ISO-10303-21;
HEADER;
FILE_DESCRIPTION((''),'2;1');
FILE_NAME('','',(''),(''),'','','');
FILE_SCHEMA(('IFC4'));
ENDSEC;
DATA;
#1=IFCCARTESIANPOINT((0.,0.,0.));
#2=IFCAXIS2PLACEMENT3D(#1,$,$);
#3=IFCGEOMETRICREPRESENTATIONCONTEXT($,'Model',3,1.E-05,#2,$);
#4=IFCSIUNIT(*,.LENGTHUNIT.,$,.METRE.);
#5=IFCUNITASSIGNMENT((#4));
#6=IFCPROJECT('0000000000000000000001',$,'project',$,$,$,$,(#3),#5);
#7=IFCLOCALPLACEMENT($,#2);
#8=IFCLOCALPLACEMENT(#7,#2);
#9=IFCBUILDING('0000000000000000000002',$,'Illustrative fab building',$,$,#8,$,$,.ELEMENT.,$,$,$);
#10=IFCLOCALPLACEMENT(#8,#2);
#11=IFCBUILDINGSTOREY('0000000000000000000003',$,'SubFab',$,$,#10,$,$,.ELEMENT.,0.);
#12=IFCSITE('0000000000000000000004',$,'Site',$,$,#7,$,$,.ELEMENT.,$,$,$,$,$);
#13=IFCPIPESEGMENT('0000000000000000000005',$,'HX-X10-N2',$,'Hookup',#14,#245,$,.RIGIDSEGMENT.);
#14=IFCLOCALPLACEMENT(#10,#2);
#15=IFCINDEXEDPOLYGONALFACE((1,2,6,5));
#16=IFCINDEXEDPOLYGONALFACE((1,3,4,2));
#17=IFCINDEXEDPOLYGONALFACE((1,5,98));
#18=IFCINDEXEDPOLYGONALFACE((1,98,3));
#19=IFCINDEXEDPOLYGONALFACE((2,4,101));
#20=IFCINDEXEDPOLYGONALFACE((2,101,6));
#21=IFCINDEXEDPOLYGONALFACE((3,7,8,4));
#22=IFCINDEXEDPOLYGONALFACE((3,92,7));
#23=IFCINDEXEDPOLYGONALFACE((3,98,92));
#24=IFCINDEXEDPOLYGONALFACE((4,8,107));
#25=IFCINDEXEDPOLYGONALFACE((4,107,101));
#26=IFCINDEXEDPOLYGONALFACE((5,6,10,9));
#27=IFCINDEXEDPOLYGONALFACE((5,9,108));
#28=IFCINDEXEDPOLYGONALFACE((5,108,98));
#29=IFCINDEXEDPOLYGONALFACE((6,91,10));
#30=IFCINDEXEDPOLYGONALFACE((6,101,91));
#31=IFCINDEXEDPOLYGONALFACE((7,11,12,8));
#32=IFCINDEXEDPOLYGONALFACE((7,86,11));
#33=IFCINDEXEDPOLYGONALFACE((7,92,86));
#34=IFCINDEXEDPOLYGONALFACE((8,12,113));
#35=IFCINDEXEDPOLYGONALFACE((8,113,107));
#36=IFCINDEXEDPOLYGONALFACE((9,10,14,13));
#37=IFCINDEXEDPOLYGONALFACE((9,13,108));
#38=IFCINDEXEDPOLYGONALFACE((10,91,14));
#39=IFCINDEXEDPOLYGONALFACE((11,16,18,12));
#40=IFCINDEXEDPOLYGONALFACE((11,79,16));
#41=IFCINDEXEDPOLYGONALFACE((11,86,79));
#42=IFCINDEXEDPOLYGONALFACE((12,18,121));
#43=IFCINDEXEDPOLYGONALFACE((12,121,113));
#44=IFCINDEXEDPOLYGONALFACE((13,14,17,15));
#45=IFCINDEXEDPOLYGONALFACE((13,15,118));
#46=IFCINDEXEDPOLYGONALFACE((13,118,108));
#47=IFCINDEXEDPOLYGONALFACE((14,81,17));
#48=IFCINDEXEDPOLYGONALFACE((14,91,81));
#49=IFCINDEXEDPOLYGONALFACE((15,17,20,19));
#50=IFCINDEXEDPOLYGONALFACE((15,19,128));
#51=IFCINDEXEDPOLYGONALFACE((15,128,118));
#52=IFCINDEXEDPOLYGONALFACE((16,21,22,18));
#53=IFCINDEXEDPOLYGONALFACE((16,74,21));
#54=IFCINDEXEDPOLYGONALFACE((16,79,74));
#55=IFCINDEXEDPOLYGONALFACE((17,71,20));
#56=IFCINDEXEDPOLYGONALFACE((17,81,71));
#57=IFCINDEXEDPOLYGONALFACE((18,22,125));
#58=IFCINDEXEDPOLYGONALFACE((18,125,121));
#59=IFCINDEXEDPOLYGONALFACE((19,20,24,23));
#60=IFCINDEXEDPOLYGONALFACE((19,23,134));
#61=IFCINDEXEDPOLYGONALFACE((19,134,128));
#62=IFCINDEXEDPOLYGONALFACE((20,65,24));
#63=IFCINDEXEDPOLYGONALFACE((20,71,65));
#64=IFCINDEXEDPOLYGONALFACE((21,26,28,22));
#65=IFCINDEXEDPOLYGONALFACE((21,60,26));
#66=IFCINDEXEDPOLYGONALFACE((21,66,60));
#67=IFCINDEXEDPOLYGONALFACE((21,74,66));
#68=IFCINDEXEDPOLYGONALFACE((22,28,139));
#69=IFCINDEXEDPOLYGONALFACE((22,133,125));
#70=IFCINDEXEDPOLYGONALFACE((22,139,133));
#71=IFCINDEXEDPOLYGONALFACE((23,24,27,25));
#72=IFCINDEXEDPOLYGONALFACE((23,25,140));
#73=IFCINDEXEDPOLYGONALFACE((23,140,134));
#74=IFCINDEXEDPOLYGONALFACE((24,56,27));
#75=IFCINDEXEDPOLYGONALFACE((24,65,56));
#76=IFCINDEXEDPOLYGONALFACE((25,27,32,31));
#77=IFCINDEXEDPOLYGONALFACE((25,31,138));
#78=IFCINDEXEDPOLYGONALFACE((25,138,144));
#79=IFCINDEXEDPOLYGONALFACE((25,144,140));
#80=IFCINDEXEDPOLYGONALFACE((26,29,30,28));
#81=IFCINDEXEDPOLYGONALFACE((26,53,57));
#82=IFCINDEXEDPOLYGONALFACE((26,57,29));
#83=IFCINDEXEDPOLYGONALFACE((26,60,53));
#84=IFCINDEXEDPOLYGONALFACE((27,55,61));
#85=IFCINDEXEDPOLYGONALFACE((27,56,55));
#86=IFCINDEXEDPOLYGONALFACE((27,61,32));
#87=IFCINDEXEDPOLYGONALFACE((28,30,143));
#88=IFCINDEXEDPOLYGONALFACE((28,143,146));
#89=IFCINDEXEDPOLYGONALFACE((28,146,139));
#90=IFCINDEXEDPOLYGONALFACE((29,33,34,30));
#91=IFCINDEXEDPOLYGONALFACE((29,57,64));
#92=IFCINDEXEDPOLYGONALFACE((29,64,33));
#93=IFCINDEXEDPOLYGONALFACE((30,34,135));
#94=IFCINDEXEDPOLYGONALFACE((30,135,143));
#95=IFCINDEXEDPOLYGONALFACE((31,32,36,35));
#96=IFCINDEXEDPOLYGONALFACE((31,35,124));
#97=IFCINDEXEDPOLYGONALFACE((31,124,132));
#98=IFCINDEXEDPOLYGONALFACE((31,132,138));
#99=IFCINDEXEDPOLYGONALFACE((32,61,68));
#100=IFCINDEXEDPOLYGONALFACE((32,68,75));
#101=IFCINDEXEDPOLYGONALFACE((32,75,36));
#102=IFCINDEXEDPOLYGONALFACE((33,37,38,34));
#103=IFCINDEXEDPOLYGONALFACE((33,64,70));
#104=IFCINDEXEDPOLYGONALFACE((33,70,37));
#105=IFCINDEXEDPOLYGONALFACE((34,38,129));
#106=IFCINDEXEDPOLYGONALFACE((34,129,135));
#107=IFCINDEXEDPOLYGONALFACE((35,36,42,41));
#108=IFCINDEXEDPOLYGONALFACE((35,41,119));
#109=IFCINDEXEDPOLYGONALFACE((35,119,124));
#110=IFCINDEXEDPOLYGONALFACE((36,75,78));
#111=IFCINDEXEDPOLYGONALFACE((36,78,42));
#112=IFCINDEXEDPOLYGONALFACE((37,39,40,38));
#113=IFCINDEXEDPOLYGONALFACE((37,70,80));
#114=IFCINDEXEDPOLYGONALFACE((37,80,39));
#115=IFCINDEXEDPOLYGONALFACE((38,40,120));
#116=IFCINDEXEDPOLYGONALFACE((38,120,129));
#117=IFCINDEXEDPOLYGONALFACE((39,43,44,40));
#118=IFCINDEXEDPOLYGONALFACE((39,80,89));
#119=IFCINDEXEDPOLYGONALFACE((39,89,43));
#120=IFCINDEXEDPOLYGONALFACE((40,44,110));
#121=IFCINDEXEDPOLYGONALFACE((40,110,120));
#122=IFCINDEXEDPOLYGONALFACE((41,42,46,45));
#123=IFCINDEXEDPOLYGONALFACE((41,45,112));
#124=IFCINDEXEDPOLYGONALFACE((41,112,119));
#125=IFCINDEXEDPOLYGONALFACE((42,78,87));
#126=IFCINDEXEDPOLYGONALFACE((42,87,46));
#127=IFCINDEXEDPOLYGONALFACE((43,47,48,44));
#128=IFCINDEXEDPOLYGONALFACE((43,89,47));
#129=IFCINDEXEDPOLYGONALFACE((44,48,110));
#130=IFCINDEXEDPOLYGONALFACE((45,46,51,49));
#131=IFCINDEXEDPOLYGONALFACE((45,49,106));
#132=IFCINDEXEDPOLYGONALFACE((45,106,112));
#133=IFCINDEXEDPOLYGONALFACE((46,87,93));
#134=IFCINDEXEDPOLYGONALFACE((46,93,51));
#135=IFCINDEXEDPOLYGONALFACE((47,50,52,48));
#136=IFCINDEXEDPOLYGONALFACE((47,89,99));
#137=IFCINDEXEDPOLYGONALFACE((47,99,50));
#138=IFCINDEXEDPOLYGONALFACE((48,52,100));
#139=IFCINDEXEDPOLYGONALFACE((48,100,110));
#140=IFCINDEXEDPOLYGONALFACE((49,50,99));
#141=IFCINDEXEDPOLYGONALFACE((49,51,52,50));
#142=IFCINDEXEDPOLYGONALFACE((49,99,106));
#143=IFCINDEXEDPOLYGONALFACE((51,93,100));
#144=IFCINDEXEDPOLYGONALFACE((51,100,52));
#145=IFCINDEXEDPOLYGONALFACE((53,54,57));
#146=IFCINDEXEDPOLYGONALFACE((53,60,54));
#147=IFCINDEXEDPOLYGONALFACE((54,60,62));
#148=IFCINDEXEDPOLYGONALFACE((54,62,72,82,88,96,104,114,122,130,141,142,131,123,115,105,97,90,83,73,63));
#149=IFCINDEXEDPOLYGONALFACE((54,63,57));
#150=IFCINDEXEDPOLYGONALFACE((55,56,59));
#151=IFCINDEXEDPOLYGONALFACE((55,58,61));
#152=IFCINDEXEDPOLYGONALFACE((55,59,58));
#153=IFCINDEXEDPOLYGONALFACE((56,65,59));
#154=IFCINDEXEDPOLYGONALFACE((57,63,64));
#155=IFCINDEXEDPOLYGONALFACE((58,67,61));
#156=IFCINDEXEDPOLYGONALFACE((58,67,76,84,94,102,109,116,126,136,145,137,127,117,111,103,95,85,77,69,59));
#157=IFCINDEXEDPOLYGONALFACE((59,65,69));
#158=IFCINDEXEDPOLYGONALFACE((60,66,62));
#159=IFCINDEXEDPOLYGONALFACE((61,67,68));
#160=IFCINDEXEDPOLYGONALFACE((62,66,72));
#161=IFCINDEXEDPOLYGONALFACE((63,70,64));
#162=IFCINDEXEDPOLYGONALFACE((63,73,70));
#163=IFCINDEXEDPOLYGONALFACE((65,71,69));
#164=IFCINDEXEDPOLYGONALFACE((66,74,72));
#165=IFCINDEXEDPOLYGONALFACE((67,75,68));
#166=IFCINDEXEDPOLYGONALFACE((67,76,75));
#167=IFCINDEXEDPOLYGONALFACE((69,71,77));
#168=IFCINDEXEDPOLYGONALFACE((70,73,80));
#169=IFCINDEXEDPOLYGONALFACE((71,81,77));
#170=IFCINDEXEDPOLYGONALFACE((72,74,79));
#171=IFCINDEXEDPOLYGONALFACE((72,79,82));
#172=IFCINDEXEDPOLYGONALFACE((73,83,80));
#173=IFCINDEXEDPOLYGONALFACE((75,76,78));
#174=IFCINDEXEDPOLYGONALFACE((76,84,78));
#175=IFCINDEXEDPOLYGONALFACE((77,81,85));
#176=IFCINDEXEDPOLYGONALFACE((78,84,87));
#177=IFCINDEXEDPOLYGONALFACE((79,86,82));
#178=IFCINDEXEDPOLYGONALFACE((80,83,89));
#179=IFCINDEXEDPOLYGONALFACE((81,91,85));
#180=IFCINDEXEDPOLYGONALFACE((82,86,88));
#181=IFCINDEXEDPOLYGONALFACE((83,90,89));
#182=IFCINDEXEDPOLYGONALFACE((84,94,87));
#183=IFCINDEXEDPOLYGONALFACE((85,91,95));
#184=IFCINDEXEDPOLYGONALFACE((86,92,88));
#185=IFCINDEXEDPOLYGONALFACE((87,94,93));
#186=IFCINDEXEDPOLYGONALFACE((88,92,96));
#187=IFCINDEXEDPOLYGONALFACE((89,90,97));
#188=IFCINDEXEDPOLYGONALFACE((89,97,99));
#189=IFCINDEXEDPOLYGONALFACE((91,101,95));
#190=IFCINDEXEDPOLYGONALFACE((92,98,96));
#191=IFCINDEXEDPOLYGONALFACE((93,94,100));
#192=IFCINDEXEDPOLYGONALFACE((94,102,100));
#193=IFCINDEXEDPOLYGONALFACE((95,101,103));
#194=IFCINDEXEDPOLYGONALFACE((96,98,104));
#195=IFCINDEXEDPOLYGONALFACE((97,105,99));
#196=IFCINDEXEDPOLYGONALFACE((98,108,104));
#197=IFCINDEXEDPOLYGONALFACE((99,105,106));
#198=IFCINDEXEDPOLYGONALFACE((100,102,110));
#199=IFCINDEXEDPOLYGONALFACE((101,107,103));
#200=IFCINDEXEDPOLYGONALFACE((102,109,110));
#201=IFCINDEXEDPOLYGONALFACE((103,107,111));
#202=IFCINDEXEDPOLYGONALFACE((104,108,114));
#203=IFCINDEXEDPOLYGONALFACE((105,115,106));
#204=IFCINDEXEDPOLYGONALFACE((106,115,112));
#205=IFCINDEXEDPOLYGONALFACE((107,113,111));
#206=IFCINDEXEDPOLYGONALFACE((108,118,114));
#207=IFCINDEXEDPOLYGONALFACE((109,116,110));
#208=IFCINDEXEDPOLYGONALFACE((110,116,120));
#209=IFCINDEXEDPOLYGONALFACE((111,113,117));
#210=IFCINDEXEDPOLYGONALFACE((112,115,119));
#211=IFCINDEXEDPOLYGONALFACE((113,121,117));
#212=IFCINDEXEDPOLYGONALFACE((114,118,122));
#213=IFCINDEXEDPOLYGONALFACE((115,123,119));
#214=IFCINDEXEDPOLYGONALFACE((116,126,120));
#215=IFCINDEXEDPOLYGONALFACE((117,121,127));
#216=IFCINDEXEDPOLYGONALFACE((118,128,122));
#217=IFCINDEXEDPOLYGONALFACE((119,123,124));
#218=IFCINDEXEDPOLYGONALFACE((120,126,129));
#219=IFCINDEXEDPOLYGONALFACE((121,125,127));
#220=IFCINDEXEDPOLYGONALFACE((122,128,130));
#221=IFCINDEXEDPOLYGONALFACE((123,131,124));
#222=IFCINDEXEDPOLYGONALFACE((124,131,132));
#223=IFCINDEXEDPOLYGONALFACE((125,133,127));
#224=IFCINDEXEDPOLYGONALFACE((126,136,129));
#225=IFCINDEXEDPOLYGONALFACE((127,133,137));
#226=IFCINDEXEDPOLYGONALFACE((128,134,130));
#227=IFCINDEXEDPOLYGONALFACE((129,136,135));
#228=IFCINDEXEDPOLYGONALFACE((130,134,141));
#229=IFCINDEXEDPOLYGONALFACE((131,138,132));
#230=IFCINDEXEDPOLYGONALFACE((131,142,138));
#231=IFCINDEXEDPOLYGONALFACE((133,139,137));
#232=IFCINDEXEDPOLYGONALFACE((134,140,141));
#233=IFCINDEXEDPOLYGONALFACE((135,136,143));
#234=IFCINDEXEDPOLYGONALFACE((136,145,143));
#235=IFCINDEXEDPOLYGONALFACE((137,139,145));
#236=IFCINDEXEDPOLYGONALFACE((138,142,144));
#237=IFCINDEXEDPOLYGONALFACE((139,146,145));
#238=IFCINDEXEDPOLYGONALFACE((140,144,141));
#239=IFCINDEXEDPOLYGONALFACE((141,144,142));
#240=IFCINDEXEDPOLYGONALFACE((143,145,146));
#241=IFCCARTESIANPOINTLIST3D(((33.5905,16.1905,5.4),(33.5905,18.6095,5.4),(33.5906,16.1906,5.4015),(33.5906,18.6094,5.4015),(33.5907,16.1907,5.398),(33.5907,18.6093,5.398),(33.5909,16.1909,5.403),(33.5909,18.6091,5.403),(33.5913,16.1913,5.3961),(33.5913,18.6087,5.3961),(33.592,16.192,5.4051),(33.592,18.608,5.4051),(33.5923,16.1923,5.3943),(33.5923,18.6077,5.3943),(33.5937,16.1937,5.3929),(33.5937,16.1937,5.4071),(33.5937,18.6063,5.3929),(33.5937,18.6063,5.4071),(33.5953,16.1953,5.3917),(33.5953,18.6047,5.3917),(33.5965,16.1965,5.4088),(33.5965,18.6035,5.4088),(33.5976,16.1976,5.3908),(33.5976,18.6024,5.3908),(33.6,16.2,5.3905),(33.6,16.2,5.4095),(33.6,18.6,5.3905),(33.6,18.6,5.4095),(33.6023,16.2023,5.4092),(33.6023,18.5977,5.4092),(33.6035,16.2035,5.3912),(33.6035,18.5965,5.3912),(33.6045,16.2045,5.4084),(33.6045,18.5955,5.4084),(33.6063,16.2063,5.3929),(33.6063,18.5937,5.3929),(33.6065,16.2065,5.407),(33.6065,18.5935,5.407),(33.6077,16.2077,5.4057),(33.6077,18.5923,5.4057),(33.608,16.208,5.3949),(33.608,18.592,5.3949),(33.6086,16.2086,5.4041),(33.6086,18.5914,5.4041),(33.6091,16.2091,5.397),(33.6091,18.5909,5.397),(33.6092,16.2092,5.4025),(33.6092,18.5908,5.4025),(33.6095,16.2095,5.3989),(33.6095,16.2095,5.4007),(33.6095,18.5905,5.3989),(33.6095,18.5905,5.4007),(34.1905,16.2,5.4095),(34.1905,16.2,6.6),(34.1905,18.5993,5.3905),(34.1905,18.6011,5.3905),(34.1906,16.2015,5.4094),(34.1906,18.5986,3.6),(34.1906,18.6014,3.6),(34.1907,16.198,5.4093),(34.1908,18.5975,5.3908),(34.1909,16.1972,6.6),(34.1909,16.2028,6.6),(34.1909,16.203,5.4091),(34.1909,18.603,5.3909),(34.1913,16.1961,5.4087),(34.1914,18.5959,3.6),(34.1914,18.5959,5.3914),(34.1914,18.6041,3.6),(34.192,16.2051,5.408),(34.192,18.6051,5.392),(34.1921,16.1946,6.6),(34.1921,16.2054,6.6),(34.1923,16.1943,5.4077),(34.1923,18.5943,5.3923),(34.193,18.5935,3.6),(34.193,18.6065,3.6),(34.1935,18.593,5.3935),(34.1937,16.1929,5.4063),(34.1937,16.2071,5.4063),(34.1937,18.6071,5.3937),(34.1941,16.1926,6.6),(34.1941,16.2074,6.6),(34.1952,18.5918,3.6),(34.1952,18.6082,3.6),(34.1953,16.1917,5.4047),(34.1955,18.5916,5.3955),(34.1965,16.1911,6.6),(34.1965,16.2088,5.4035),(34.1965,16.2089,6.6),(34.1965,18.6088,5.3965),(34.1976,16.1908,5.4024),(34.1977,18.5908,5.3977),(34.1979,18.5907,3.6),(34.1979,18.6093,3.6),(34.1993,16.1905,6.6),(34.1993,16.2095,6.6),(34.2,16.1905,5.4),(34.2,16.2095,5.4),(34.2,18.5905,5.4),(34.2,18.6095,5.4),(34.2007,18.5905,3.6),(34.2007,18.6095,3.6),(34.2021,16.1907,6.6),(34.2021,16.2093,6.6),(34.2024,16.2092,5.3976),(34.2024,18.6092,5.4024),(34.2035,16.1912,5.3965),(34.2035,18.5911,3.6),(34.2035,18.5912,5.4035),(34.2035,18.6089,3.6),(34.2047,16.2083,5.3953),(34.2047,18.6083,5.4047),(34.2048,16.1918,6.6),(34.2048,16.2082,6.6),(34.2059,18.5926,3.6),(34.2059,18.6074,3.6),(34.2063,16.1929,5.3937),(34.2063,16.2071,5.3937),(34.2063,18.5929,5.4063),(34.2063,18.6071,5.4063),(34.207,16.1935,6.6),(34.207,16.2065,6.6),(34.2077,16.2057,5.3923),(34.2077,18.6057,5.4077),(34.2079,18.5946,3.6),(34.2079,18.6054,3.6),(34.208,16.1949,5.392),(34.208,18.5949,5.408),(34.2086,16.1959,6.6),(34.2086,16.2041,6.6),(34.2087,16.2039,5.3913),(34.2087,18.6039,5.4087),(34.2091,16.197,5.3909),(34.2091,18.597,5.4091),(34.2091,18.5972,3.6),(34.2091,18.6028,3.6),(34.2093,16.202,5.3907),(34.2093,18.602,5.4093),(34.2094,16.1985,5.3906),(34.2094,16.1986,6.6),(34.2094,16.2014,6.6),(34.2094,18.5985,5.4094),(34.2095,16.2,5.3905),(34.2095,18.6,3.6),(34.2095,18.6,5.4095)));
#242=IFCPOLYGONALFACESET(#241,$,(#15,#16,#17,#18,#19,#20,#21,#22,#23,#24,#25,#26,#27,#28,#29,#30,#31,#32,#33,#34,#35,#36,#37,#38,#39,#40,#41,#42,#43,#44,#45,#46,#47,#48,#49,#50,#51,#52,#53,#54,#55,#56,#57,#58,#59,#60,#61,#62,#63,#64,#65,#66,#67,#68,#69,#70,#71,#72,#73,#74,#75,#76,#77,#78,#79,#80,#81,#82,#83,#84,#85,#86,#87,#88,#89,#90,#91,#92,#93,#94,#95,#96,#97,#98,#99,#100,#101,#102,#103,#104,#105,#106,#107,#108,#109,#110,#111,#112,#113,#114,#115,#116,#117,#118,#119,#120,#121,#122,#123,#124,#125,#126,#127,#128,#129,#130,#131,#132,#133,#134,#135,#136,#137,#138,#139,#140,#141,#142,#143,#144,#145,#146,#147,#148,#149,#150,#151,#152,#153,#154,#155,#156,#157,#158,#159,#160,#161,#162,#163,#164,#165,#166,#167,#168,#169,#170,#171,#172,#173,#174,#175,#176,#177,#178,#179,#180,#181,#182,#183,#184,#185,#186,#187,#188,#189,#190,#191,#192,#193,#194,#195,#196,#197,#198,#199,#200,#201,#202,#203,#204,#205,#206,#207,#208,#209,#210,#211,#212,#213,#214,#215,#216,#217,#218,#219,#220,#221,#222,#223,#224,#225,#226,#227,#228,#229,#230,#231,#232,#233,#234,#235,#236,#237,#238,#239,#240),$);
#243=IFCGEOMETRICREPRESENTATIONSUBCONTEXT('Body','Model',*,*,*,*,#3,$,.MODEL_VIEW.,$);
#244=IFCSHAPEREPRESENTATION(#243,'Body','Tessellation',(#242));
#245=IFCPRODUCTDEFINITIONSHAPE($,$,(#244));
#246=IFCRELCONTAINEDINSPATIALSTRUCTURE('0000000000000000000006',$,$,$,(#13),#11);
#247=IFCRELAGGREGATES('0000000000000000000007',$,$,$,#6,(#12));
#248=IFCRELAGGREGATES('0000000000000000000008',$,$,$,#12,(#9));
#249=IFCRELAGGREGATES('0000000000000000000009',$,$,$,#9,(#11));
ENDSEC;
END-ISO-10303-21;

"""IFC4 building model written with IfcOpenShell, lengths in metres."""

from ifc_helpers import new_model, entity, si_unit, origin, place, context, subcontext, project, spatial, element, save


model = new_model("IFC4")

# Units and contexts
model_context = context("Model", 3, precision=1e-05, world=origin())
body_context = subcontext(model_context, "Body", "Model", "MODEL_VIEW")
ifc_project = project(units=[si_unit("LENGTHUNIT", "METRE")], contexts=[model_context])

# Site, building, storey
site_placement = place(None, origin())
site = spatial("IfcSite", under=ifc_project, at=site_placement, Name="Site", CompositionType="ELEMENT")
building_placement = place(site_placement, origin())
building = spatial("IfcBuilding", under=site, at=building_placement, Name="Illustrative fab building", CompositionType="ELEMENT")
storey_placement = place(building_placement, origin())
storey = spatial("IfcBuildingStorey", under=building, at=storey_placement, Name="SubFab", CompositionType="ELEMENT", Elevation=0.0)

# Pipe segment
pipe_segment_1_placement = place(storey_placement, origin())
element("IfcPipeSegment", 1, at=pipe_segment_1_placement, inside=storey, Name="HX-X10-N2", ObjectType="Hookup", PredefinedType="RIGIDSEGMENT", context=body_context, shape_type="AdvancedSweptSolid", body=[
    entity("IfcSweptDiskSolid", entity("IfcPolyline", [entity("IfcCartesianPoint", [34.2, 18.6, 3.6]), entity("IfcCartesianPoint", [34.2, 18.6, 5.4]), entity("IfcCartesianPoint", [33.6, 18.6, 5.4]), entity("IfcCartesianPoint", [33.6, 16.2, 5.4]), entity("IfcCartesianPoint", [34.2, 16.2, 5.4]), entity("IfcCartesianPoint", [34.2, 16.2, 6.6])]), 0.0095),
])

save(model, "model.ifc")
